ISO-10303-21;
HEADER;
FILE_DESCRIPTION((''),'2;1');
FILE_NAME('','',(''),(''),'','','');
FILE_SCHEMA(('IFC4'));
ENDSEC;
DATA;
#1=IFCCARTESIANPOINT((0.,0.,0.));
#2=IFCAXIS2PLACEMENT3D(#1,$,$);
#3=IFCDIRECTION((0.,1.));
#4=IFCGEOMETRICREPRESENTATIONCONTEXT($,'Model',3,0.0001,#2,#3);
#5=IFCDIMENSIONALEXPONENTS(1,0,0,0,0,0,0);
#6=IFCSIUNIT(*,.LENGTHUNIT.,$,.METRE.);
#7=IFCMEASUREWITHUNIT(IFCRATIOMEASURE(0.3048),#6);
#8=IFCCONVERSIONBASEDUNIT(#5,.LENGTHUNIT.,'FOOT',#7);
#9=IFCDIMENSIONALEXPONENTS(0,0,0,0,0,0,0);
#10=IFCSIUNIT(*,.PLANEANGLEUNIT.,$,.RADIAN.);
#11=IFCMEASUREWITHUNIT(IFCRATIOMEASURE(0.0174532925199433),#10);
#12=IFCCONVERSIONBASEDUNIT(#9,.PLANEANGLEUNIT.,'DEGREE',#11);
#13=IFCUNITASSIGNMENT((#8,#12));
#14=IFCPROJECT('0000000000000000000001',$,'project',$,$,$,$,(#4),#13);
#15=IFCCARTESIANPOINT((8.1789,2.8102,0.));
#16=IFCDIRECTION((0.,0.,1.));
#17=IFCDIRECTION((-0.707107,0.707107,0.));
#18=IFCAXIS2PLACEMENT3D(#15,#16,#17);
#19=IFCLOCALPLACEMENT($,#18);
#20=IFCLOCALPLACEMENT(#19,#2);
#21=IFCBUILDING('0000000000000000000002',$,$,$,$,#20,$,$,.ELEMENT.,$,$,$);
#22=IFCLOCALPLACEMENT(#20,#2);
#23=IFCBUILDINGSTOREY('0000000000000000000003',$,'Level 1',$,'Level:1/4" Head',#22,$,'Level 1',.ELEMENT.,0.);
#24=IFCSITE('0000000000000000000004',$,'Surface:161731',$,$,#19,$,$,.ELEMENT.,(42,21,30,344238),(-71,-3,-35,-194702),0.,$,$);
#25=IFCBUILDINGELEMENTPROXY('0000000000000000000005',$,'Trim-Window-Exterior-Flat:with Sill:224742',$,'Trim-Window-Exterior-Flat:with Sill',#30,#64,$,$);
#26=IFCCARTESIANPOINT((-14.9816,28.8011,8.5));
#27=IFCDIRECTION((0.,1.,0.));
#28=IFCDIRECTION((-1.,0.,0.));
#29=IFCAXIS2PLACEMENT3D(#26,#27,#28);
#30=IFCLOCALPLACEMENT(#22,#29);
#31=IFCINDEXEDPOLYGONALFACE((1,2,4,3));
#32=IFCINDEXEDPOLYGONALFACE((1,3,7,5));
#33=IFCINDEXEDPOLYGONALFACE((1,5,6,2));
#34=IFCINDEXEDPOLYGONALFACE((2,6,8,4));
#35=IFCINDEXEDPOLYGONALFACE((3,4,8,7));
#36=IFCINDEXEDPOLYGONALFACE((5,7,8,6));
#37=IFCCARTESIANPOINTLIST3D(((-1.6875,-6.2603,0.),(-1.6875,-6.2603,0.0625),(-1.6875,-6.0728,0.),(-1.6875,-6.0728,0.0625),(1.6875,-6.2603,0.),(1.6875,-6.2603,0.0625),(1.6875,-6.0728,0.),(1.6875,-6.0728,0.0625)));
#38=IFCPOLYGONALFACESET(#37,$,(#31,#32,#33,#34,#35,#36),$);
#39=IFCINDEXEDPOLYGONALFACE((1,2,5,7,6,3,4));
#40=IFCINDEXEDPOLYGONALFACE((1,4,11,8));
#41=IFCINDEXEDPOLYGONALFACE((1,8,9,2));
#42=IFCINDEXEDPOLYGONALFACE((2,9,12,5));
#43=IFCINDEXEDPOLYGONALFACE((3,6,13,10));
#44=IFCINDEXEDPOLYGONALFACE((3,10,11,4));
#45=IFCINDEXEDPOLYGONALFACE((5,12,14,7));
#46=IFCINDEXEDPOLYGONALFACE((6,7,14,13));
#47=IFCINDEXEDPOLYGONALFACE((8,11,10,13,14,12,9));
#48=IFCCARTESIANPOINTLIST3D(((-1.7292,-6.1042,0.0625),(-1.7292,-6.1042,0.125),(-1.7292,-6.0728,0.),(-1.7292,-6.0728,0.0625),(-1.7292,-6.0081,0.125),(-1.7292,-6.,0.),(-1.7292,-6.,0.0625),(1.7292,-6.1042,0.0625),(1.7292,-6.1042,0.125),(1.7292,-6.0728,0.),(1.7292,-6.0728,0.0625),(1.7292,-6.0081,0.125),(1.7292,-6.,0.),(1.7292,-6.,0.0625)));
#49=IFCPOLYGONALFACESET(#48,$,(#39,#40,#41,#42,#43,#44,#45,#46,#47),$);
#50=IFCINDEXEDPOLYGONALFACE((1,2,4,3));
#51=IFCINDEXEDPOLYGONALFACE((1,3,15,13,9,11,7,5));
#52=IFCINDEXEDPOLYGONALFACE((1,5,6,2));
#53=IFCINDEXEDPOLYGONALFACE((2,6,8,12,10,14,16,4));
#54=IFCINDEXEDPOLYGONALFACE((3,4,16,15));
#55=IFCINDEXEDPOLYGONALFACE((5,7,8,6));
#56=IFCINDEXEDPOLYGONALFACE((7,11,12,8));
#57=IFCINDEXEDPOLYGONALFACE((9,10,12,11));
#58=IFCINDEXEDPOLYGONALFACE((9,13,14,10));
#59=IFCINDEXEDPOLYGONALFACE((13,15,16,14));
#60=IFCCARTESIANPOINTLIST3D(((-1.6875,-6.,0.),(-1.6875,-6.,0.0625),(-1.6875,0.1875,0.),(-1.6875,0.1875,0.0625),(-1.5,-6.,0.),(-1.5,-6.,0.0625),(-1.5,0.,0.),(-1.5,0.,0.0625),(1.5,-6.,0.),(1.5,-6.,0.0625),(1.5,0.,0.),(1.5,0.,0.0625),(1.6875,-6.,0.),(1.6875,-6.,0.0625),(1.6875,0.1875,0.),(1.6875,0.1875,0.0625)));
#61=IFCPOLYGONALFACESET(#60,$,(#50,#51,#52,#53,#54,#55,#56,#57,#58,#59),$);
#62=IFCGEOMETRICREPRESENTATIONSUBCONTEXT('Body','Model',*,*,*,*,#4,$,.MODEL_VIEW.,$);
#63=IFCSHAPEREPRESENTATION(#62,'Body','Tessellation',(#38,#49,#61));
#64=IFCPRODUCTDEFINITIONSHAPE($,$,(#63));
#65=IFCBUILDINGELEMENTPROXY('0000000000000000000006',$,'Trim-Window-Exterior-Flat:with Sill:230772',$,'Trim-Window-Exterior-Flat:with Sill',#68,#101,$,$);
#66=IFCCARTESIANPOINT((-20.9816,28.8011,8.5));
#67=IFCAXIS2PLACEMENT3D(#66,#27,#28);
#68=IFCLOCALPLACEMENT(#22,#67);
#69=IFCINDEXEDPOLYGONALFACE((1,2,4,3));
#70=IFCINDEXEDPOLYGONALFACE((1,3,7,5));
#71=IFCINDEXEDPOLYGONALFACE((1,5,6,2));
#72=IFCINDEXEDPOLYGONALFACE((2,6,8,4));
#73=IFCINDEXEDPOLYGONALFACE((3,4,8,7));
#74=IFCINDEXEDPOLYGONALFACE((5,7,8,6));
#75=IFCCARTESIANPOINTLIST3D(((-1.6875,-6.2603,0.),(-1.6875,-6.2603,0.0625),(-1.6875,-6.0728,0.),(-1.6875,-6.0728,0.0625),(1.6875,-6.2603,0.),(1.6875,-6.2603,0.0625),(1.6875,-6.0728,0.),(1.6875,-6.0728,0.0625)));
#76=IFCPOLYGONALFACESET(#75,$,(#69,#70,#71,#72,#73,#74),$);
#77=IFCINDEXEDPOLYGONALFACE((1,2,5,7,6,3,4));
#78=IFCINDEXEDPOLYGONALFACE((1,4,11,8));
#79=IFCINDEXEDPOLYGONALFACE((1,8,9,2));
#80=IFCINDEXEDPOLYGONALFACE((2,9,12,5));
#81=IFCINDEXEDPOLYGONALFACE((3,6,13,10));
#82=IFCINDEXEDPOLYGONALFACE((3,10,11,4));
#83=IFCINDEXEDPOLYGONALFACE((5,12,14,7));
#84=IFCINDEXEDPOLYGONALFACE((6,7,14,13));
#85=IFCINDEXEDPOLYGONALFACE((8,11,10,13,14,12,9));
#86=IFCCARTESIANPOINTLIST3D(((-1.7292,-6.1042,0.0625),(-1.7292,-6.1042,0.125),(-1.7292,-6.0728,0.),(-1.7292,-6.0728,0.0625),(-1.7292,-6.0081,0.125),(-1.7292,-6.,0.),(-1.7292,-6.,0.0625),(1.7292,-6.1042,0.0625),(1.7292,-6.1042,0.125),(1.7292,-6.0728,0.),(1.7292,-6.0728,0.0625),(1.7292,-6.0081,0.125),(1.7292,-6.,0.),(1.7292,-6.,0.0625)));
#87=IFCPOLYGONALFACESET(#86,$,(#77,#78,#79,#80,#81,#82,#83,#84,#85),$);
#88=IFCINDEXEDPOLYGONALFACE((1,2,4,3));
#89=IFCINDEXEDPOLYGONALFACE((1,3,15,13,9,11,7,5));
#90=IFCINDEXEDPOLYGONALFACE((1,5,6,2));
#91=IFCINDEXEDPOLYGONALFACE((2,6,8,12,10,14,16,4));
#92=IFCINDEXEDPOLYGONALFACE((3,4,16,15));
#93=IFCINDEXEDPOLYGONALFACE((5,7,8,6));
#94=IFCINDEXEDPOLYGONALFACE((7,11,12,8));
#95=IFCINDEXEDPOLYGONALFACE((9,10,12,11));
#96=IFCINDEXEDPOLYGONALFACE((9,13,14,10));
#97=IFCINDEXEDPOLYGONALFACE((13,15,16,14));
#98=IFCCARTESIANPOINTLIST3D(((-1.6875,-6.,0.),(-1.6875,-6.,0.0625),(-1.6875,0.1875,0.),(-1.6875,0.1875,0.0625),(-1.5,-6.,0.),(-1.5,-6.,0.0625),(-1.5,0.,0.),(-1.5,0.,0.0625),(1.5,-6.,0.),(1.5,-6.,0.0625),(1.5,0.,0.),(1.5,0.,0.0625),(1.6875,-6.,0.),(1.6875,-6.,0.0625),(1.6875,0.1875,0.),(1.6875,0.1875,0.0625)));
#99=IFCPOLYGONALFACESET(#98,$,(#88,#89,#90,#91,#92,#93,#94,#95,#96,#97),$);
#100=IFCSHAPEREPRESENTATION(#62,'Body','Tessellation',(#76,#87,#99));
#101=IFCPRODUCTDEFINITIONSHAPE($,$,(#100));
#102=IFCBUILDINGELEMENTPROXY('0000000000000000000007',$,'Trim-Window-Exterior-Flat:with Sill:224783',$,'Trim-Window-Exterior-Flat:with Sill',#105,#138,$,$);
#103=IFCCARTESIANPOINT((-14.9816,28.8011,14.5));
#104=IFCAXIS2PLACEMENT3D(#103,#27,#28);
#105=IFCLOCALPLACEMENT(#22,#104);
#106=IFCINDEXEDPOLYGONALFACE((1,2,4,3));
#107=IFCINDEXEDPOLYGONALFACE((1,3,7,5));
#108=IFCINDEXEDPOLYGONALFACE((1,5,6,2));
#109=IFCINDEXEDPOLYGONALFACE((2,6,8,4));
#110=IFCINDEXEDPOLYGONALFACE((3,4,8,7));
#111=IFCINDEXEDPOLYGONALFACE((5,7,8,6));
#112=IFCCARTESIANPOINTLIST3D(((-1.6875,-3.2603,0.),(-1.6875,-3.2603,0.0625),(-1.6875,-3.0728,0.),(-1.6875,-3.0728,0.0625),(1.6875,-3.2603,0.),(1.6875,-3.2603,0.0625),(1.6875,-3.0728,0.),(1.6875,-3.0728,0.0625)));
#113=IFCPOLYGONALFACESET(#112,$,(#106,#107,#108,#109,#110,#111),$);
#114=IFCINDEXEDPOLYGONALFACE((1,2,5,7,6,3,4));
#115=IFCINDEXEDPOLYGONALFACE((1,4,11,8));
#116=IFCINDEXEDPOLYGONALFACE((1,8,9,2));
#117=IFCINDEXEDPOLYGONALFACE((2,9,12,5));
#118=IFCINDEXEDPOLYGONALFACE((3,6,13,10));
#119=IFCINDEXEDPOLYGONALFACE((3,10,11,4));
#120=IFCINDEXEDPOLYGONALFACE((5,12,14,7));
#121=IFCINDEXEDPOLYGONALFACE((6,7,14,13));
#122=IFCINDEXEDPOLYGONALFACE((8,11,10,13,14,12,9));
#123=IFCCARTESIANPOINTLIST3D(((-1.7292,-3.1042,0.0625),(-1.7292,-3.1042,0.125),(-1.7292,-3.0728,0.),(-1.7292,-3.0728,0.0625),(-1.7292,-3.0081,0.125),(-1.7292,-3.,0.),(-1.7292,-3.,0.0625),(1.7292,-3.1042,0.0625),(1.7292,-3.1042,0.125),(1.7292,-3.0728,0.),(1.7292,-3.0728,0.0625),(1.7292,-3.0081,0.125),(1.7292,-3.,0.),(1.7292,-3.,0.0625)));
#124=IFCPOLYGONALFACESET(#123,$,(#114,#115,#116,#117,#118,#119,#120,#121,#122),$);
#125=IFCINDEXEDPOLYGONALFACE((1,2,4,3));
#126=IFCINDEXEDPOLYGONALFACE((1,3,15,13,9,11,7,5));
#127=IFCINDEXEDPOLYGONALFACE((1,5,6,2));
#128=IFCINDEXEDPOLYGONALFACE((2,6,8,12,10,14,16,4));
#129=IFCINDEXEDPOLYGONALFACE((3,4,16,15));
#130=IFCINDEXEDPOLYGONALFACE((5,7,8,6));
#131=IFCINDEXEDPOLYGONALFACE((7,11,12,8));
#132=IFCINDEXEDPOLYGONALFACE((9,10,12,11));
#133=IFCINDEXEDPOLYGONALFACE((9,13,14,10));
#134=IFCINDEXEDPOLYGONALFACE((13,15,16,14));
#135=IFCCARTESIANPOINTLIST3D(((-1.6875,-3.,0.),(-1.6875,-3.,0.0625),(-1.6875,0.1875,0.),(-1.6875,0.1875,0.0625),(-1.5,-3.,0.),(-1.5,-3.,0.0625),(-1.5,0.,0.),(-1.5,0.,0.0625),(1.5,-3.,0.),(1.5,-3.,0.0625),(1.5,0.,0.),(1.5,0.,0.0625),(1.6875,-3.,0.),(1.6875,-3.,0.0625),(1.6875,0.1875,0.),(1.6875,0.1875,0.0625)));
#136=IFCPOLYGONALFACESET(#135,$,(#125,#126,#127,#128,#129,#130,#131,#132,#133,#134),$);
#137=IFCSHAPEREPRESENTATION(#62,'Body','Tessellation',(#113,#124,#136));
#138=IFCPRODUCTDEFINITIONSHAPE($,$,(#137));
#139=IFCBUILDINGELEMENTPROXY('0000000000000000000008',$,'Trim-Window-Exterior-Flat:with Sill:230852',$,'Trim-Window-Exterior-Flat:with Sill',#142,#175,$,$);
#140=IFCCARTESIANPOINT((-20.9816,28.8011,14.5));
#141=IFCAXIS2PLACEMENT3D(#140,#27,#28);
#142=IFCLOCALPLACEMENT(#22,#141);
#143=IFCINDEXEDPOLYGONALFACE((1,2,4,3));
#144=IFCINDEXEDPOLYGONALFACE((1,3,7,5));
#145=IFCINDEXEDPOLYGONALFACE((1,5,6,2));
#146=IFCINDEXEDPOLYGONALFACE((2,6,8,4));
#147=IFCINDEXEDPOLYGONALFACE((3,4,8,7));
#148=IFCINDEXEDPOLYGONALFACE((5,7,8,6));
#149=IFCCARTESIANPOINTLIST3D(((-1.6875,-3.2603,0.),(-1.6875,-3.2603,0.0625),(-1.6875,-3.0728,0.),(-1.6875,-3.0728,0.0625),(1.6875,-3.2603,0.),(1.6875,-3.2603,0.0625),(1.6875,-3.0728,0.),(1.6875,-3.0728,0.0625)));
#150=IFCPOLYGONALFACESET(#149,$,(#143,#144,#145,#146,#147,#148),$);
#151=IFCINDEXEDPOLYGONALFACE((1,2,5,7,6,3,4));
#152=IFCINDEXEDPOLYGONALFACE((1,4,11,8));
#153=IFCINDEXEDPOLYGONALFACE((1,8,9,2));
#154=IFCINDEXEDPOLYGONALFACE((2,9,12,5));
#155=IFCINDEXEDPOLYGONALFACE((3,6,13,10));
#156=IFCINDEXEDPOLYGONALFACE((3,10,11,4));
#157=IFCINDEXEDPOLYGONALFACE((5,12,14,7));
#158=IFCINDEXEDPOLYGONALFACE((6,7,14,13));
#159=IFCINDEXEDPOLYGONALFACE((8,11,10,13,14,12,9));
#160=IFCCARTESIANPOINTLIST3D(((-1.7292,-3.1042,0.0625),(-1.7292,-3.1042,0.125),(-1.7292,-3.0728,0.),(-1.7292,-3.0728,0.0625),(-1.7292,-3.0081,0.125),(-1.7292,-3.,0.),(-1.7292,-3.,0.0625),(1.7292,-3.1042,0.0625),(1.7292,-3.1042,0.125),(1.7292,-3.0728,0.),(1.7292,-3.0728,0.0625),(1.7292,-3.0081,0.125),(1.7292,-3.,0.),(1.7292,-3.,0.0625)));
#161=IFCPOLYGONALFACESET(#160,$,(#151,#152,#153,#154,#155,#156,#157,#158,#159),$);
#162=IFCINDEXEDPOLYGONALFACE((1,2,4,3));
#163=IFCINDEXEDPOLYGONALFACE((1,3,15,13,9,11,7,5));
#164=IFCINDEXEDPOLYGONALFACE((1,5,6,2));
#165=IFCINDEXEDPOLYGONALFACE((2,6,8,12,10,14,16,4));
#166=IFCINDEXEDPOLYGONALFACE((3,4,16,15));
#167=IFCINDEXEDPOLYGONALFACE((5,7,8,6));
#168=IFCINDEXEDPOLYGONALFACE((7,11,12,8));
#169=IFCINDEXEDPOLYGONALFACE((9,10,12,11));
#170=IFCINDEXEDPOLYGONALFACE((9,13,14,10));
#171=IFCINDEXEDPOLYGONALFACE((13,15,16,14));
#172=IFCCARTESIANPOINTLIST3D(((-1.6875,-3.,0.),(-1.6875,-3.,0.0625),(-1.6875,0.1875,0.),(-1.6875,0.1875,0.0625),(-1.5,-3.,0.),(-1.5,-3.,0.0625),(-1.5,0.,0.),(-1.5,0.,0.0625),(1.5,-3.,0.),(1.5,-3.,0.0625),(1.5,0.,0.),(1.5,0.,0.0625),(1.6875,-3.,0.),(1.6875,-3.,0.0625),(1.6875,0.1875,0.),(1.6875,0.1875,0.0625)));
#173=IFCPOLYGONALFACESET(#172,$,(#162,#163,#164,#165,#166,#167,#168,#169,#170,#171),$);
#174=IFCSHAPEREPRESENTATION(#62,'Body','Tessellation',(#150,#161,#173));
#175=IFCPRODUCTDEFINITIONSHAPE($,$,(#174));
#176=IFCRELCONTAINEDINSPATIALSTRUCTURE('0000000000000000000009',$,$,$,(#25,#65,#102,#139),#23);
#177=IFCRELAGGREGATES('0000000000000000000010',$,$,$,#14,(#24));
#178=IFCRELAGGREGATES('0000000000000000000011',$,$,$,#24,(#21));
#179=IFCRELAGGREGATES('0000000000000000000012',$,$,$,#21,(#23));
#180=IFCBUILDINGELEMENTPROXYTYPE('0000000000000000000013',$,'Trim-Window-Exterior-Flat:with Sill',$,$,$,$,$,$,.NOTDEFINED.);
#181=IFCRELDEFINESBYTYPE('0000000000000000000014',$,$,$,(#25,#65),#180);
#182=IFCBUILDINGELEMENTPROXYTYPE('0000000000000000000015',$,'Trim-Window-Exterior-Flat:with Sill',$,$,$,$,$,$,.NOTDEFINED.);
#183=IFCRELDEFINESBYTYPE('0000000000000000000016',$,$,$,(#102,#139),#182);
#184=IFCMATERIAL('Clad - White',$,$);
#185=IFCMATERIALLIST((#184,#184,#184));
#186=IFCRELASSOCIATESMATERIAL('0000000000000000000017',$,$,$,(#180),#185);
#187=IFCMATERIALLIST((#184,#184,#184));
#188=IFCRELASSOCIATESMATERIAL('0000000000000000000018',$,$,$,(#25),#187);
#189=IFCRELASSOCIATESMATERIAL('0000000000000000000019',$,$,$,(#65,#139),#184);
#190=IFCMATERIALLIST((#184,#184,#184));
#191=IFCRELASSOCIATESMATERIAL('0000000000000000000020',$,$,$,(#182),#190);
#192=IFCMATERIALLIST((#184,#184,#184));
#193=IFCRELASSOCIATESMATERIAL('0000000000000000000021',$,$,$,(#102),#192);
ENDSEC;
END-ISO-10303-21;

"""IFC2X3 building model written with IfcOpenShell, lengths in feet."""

from ifc_helpers import new_model, entity, si_unit, converted_unit, direction, frame, frame_2d, origin, origin_2d_with_axis, place, context, subcontext, project, spatial, polyline, rectangle, outline, extrude, source, transform, mapped, material, material_list, type_object, type_shapes, element, save


model = new_model("IFC2X3")

# Units and contexts
model_context = context("Model", 3, precision=0.0001, world=origin(), true_north=direction((0.0, 1.0)))
body_context = subcontext(model_context, "Body", "Model", "MODEL_VIEW")
ifc_project = project(units=[converted_unit("LENGTHUNIT", "FOOT", entity("IfcRatioMeasure", 0.3048), si_unit("LENGTHUNIT", "METRE"), dimensions=[1, 0, 0, 0, 0, 0, 0]), converted_unit("PLANEANGLEUNIT", "DEGREE", entity("IfcRatioMeasure", 0.0174532925199433), si_unit("PLANEANGLEUNIT", "RADIAN"), dimensions=[0, 0, 0, 0, 0, 0, 0])], contexts=[model_context])

# Site, building, storey
site_placement = place(None, frame((8.1789, 2.8102, 0.0), z_axis=(0.0, 0.0, 1.0), x_axis=(-0.707107, 0.707107, 0.0)))
site = spatial("IfcSite", under=ifc_project, at=site_placement, Name="Surface:161731", CompositionType="ELEMENT", RefLatitude=(42, 21, 30, 344238), RefLongitude=(-71, -3, -35, -194702), RefElevation=0.0)
building_placement = place(site_placement, origin())
building = spatial("IfcBuilding", under=site, at=building_placement, CompositionType="ELEMENT")
storey_placement = place(building_placement, origin())
storey = spatial("IfcBuildingStorey", under=building, at=storey_placement, Name="Level 1", ObjectType="Level:1/4\" Head", LongName="Level 1", CompositionType="ELEMENT", Elevation=0.0)

# Building element proxies
ifc_material_1 = material(Name="Clad - White")
ifc_material_list_1 = material_list([ifc_material_1, ifc_material_1, ifc_material_1])
ifc_material_list_2 = material_list([ifc_material_1, ifc_material_1, ifc_material_1])
building_element_proxy_type_1 = type_object("IfcBuildingElementProxyType", Name="Trim-Window-Exterior-Flat:with Sill", PredefinedType="NOTDEFINED", material=ifc_material_list_2)
shared_shape_1 = source(origin(), body_context, "Body", "SweptSolid", [
    extrude(rectangle(XDim=3.375, YDim=0.1875, at=origin_2d_with_axis()), frame((0.0, -6.1665, 0.0), z_axis=(0.0, 0.0, 1.0), x_axis=(-1.0, 0.0, 0.0)), (0.0, 0.0, 1.0), 0.0625),
    extrude(outline(polyline([(-0.0625, -0.0525), (0.0, -0.0525), (0.0, -0.0211), (0.0625, -0.0211), (0.0625, 0.0517), (0.0, 0.0517), (-0.0625, 0.0436), (-0.0625, -0.0525)])), frame((-1.7292, -6.0517, 0.0625), z_axis=(1.0, 0.0, 0.0), x_axis=(0.0, 0.0, -1.0)), (0.0, 0.0, 1.0), 3.4583),
    extrude(outline(polyline([(-3.1406, -1.6875), (3.0469, -1.6875), (3.0469, -1.5), (-2.9531, -1.5), (-2.9531, 1.5), (3.0469, 1.5), (3.0469, 1.6875), (-3.1406, 1.6875), (-3.1406, -1.6875)])), frame((0.0, -2.9531, 0.0), z_axis=(0.0, 0.0, 1.0), x_axis=(0.0, -1.0, 0.0)), (0.0, 0.0, 1.0), 0.0625),
])
type_shapes(building_element_proxy_type_1, [shared_shape_1])
proxy_1_placement = place(storey_placement, frame((-14.9816, 28.8011, 8.5), z_axis=(0.0, 1.0, 0.0), x_axis=(-1.0, 0.0, 0.0)))
element("IfcBuildingElementProxy", 1, at=proxy_1_placement, inside=storey, type_object=building_element_proxy_type_1, material=ifc_material_list_1, Name="Trim-Window-Exterior-Flat:with Sill:224742", ObjectType="Trim-Window-Exterior-Flat:with Sill", context=body_context, shape_type="MappedRepresentation", body=[
    mapped(shared_shape_1, transform((0.0, 0.0, 0.0), scale=1.0)),
])
proxy_2_placement = place(storey_placement, frame((-20.9816, 28.8011, 8.5), z_axis=(0.0, 1.0, 0.0), x_axis=(-1.0, 0.0, 0.0)))
element("IfcBuildingElementProxy", 2, at=proxy_2_placement, inside=storey, type_object=building_element_proxy_type_1, material=ifc_material_1, Name="Trim-Window-Exterior-Flat:with Sill:230772", ObjectType="Trim-Window-Exterior-Flat:with Sill", context=body_context, shape_type="MappedRepresentation", body=[
    mapped(shared_shape_1, transform((0.0, 0.0, 0.0), scale=1.0)),
])
ifc_material_list_3 = material_list([ifc_material_1, ifc_material_1, ifc_material_1])
ifc_material_list_4 = material_list([ifc_material_1, ifc_material_1, ifc_material_1])
building_element_proxy_type_2 = type_object("IfcBuildingElementProxyType", Name="Trim-Window-Exterior-Flat:with Sill", PredefinedType="NOTDEFINED", material=ifc_material_list_4)
shared_shape_2 = source(origin(), body_context, "Body", "SweptSolid", [
    extrude(rectangle(XDim=3.375, YDim=0.1875, at=frame_2d((0.0, 0.0), x_axis=(1.0, 0.0))), frame((0.0, -3.1665, 0.0), z_axis=(0.0, 0.0, 1.0), x_axis=(-1.0, 0.0, 0.0)), (0.0, 0.0, 1.0), 0.0625),
    extrude(outline(polyline([(-0.0625, -0.0525), (0.0, -0.0525), (0.0, -0.0211), (0.0625, -0.0211), (0.0625, 0.0517), (0.0, 0.0517), (-0.0625, 0.0436), (-0.0625, -0.0525)])), frame((-1.7292, -3.0517, 0.0625), z_axis=(1.0, 0.0, 0.0), x_axis=(0.0, 0.0, -1.0)), (0.0, 0.0, 1.0), 3.4583),
    extrude(outline(polyline([(-1.6406, -1.6875), (1.5469, -1.6875), (1.5469, -1.5), (-1.4531, -1.5), (-1.4531, 1.5), (1.5469, 1.5), (1.5469, 1.6875), (-1.6406, 1.6875), (-1.6406, -1.6875)])), frame((0.0, -1.4531, 0.0), z_axis=(0.0, 0.0, 1.0), x_axis=(0.0, -1.0, 0.0)), (0.0, 0.0, 1.0), 0.0625),
])
type_shapes(building_element_proxy_type_2, [shared_shape_2])
proxy_3_placement = place(storey_placement, frame((-14.9816, 28.8011, 14.5), z_axis=(0.0, 1.0, 0.0), x_axis=(-1.0, 0.0, 0.0)))
element("IfcBuildingElementProxy", 3, at=proxy_3_placement, inside=storey, type_object=building_element_proxy_type_2, material=ifc_material_list_3, Name="Trim-Window-Exterior-Flat:with Sill:224783", ObjectType="Trim-Window-Exterior-Flat:with Sill", context=body_context, shape_type="MappedRepresentation", body=[
    mapped(shared_shape_2, transform((0.0, 0.0, 0.0), scale=1.0)),
])
proxy_4_placement = place(storey_placement, frame((-20.9816, 28.8011, 14.5), z_axis=(0.0, 1.0, 0.0), x_axis=(-1.0, 0.0, 0.0)))
element("IfcBuildingElementProxy", 4, at=proxy_4_placement, inside=storey, type_object=building_element_proxy_type_2, material=ifc_material_1, Name="Trim-Window-Exterior-Flat:with Sill:230852", ObjectType="Trim-Window-Exterior-Flat:with Sill", context=body_context, shape_type="MappedRepresentation", body=[
    mapped(shared_shape_2, transform((0.0, 0.0, 0.0), scale=1.0)),
])

save(model, "model.ifc")
